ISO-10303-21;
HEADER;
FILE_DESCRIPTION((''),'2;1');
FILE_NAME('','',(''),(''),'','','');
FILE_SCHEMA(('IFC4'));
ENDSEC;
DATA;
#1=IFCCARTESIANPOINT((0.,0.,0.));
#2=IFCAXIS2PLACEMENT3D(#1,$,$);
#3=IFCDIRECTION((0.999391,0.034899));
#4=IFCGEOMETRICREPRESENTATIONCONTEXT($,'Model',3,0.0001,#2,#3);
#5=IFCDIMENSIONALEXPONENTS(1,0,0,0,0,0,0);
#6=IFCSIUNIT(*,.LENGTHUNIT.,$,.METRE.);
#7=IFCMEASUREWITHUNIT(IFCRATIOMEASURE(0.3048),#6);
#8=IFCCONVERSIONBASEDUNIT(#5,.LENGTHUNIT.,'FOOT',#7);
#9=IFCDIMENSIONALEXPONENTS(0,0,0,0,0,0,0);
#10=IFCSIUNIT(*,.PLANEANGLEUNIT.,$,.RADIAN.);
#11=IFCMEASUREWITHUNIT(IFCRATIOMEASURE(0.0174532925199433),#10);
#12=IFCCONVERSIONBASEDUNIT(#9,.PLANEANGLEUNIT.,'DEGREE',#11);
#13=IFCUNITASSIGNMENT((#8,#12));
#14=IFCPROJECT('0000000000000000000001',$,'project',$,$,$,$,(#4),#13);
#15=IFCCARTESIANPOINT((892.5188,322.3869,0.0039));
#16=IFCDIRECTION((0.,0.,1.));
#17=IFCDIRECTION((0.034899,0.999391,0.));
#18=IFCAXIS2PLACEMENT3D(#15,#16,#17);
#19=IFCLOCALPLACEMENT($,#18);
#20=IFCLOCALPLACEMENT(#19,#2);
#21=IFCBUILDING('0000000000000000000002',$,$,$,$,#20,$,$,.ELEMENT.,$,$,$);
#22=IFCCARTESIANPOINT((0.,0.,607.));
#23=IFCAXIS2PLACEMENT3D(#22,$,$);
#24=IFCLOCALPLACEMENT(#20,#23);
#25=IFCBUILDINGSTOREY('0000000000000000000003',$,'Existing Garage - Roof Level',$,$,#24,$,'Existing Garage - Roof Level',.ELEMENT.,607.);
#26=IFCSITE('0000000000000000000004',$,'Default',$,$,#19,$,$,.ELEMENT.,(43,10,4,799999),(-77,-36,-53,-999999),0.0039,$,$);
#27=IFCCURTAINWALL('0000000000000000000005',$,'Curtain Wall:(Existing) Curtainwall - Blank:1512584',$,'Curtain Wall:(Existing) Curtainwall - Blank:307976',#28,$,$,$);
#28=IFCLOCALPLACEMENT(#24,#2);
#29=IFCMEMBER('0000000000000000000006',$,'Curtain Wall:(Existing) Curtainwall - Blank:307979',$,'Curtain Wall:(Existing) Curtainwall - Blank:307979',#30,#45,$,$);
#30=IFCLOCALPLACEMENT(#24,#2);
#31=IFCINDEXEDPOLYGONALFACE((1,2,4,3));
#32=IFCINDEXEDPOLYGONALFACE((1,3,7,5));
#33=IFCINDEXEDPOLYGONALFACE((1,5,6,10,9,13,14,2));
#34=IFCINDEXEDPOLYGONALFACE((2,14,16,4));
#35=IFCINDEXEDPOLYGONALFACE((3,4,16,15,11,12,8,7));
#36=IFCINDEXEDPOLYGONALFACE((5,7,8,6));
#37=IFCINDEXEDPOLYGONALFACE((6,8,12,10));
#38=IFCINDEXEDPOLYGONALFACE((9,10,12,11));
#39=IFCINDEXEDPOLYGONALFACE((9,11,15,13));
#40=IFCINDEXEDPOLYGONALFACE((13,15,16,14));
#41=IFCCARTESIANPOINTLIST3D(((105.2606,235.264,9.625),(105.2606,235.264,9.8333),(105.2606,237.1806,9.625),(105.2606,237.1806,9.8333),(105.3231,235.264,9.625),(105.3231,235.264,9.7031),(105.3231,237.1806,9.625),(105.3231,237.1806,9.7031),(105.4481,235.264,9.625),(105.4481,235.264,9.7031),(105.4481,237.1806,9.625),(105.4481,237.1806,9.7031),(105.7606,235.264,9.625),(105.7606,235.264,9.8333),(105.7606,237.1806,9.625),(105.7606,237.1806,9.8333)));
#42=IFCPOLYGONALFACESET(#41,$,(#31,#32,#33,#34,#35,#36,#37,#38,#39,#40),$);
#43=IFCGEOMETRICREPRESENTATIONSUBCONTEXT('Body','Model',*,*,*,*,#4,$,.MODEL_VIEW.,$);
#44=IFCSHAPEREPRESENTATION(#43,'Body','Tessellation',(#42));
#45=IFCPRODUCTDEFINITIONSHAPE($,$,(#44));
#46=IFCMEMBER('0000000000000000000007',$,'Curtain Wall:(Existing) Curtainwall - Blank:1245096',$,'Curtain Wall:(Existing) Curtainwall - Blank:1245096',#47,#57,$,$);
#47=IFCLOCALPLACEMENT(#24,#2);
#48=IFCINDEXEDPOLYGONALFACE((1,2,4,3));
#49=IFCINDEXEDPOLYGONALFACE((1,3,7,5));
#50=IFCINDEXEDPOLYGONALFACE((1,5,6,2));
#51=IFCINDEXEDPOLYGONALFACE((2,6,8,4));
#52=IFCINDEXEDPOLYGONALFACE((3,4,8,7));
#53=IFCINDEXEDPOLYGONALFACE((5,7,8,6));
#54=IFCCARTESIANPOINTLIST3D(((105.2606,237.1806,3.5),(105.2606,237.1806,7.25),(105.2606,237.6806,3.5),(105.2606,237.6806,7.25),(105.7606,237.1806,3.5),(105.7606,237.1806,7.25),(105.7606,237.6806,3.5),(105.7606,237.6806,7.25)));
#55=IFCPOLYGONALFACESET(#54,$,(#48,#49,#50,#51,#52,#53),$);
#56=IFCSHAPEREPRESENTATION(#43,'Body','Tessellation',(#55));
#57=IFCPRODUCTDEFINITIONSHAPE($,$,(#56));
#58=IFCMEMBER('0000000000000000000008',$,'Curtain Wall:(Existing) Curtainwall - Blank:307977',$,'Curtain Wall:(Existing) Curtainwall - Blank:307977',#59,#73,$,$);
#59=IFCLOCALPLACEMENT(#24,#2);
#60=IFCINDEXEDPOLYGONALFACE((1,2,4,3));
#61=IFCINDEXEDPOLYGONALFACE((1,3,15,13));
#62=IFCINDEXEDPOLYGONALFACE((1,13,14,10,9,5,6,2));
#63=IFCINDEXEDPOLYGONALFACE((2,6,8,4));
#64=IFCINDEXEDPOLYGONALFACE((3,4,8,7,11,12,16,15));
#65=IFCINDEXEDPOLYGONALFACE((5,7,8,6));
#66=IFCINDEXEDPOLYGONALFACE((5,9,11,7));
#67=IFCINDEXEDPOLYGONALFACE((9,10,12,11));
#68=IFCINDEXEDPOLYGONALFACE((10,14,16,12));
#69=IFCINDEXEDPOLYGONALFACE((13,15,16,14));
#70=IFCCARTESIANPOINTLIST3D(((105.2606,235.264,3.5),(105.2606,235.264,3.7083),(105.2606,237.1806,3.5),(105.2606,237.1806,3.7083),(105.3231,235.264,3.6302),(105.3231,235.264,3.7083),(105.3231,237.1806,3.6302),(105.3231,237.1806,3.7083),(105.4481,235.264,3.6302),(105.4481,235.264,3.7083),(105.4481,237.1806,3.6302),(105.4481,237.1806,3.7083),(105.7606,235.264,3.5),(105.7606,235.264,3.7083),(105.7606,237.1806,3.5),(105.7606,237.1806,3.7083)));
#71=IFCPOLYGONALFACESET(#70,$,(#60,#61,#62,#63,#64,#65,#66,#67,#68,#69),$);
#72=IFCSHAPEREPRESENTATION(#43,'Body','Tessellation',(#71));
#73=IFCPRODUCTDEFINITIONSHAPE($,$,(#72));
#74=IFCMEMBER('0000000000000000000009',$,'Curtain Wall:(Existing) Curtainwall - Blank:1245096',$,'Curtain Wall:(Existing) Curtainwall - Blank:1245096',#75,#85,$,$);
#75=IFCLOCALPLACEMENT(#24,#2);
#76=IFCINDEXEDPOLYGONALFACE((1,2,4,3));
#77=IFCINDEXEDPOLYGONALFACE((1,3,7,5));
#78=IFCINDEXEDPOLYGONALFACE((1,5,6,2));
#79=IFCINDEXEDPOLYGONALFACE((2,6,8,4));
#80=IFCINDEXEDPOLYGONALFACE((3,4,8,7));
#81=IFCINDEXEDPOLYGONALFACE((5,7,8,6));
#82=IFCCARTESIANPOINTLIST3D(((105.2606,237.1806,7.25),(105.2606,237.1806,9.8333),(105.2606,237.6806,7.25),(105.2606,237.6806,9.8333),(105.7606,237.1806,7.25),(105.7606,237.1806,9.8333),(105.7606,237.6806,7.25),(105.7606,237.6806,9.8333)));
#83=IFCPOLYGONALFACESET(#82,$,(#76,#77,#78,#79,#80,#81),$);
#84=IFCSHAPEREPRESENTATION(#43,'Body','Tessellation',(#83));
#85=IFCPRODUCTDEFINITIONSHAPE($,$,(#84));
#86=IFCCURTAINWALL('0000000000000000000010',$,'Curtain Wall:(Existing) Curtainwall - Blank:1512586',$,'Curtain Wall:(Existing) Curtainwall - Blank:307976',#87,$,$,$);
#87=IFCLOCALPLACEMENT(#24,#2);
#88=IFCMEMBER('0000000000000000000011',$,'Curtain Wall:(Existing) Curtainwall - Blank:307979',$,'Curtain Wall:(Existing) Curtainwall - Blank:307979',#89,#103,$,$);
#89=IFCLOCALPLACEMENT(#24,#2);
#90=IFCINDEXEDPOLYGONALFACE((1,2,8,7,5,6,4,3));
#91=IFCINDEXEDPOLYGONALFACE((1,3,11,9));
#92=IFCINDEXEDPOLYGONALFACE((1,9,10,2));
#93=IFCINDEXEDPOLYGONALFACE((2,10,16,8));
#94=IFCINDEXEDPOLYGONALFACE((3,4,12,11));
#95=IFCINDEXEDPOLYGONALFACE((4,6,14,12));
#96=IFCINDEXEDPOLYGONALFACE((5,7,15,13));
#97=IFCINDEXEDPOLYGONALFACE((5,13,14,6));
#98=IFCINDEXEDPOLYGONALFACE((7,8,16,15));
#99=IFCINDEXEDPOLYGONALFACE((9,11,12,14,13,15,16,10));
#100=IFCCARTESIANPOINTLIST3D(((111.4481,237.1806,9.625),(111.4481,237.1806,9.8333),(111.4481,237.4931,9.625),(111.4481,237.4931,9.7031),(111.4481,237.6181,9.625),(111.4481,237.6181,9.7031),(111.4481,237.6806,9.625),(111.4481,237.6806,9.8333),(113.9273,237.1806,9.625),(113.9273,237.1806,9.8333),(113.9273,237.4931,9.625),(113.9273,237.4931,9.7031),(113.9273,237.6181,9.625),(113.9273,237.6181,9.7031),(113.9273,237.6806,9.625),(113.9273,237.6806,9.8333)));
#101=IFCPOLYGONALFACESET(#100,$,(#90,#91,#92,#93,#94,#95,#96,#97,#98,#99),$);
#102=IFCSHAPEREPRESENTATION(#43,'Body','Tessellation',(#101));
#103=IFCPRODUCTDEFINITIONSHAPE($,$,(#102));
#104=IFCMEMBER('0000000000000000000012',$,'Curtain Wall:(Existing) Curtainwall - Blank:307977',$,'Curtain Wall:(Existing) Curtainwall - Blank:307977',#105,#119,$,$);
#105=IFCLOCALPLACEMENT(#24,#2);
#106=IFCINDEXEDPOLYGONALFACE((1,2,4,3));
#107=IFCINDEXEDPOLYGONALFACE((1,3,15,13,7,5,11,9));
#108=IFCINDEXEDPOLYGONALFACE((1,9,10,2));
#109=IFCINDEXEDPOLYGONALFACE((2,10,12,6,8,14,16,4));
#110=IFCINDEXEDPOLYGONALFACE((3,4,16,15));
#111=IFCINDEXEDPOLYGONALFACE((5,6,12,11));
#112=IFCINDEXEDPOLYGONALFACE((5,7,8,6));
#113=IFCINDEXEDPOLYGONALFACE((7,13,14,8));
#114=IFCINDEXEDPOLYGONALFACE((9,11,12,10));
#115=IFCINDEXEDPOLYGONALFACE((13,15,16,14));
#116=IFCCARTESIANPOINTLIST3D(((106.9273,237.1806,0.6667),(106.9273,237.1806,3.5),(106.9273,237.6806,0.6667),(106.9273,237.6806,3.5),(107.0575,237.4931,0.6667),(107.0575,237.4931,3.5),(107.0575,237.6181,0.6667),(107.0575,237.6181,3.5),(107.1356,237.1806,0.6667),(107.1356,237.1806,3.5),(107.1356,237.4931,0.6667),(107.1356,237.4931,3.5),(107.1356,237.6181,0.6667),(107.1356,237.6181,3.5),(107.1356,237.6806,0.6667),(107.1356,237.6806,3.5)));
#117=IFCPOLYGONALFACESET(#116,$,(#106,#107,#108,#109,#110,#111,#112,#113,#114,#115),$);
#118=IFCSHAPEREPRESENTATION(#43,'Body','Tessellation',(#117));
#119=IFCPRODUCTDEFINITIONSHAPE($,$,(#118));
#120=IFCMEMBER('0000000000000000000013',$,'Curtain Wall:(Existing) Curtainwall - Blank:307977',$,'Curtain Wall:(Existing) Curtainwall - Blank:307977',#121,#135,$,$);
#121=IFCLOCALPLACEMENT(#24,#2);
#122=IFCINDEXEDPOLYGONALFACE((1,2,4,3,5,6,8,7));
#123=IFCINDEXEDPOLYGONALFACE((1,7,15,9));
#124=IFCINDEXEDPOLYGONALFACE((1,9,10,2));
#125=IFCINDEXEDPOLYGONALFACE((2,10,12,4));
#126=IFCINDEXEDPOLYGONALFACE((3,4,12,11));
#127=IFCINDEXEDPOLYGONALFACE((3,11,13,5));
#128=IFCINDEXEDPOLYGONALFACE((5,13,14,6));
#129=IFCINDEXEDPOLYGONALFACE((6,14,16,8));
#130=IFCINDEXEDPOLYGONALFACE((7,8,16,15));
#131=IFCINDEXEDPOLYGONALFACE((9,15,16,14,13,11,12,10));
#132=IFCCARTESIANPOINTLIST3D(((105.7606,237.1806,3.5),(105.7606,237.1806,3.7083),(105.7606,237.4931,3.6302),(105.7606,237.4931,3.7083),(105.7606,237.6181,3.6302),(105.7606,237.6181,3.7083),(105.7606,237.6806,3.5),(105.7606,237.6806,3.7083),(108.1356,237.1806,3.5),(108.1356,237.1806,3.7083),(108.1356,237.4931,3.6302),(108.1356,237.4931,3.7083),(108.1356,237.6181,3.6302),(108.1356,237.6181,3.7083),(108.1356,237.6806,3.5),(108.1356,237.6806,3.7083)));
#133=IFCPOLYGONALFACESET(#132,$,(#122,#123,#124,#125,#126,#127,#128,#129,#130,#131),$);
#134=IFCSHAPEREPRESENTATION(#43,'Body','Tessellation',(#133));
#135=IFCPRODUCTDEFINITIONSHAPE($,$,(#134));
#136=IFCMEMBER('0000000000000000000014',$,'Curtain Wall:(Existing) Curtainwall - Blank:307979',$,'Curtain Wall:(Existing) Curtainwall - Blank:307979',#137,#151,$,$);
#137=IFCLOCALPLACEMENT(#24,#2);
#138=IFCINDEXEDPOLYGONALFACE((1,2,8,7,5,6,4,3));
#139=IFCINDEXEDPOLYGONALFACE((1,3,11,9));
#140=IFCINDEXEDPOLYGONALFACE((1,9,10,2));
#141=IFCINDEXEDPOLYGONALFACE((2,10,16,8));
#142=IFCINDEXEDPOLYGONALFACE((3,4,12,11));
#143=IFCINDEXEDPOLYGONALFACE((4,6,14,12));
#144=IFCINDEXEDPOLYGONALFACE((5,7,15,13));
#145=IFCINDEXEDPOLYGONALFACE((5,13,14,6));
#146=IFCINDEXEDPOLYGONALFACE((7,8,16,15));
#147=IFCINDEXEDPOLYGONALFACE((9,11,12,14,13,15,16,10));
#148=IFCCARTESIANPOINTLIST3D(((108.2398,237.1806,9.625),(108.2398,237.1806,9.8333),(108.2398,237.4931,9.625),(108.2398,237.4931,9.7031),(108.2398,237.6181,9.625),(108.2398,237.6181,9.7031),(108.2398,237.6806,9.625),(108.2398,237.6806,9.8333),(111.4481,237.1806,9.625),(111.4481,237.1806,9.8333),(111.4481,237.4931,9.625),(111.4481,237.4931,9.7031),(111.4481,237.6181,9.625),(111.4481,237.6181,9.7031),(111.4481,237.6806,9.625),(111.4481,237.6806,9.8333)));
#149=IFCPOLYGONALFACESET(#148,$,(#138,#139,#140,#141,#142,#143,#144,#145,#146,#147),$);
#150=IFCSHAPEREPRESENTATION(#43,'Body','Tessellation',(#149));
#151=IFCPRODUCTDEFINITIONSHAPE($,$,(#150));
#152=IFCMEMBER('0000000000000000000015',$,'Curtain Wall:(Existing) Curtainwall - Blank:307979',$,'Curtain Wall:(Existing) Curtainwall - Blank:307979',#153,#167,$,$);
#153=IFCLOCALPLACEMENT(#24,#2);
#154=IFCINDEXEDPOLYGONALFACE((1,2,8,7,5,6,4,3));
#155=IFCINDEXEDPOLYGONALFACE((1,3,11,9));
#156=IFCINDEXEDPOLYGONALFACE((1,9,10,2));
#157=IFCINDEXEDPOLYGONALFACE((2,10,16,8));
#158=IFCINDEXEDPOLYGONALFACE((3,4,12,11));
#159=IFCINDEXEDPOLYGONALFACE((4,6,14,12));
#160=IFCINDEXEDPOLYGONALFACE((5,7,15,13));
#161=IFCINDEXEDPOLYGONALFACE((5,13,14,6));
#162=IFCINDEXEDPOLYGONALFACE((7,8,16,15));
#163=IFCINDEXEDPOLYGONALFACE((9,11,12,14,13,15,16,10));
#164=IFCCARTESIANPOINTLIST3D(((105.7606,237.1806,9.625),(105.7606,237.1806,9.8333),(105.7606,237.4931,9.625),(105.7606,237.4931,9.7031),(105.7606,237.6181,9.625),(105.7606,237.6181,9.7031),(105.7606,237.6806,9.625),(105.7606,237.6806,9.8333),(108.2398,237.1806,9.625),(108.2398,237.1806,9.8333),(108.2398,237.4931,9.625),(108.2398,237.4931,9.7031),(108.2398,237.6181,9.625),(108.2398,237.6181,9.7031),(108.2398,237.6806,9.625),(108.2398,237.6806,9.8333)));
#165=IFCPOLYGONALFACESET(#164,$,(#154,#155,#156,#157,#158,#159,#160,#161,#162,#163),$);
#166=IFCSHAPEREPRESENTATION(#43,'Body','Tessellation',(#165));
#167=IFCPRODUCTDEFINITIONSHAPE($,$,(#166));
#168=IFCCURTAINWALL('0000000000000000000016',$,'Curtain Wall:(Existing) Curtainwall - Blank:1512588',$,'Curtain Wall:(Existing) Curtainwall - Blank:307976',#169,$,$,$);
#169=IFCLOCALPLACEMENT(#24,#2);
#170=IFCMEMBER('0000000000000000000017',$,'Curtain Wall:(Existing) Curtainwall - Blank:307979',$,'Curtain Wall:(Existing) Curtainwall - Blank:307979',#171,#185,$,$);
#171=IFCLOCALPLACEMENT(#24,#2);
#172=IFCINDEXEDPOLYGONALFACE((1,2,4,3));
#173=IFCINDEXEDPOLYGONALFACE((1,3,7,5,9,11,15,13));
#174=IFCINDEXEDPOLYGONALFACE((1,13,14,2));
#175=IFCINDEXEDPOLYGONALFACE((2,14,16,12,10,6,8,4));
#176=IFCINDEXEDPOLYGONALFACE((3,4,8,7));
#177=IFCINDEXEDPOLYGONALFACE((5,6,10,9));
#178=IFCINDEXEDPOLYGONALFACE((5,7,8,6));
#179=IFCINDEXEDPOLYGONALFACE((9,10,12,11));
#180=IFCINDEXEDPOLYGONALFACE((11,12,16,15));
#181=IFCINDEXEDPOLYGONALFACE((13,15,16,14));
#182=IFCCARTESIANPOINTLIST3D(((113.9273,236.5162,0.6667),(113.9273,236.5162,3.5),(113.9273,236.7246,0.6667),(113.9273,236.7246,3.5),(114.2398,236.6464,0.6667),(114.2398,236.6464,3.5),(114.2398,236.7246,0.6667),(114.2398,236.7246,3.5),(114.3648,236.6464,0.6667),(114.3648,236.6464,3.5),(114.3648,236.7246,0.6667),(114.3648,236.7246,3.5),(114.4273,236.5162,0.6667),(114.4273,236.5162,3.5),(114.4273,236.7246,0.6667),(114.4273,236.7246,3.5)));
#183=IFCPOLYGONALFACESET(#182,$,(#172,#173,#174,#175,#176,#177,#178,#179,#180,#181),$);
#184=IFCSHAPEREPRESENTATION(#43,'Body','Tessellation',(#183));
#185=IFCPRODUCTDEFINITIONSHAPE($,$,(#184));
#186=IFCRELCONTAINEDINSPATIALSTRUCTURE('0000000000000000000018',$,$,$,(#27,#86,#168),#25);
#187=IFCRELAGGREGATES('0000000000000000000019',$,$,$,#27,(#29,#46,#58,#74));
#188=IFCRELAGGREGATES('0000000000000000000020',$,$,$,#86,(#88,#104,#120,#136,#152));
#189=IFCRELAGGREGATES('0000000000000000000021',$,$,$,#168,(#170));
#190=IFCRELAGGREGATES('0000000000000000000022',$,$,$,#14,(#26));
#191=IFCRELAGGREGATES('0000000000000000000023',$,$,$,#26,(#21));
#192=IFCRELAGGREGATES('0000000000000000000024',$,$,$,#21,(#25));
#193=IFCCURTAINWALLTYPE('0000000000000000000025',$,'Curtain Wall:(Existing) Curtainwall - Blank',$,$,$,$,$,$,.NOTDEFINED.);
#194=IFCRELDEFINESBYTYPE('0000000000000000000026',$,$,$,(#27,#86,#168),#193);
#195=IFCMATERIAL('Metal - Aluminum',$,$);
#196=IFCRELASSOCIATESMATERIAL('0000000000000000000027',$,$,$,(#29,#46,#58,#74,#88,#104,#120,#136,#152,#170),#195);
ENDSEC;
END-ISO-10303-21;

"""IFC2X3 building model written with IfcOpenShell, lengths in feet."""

from ifc_helpers import new_model, entity, si_unit, converted_unit, direction, frame, origin, origin_2d_with_axis, place, context, subcontext, project, spatial, polyline, rectangle, outline, extrude, material, type_object, element, aggregate, save


model = new_model("IFC2X3")

# Units and contexts
model_context = context("Model", 3, precision=0.0001, world=origin(), true_north=direction((0.999391, 0.034899)))
body_context = subcontext(model_context, "Body", "Model", "MODEL_VIEW")
ifc_project = project(units=[converted_unit("LENGTHUNIT", "FOOT", entity("IfcRatioMeasure", 0.3048), si_unit("LENGTHUNIT", "METRE"), dimensions=[1, 0, 0, 0, 0, 0, 0]), converted_unit("PLANEANGLEUNIT", "DEGREE", entity("IfcRatioMeasure", 0.0174532925199433), si_unit("PLANEANGLEUNIT", "RADIAN"), dimensions=[0, 0, 0, 0, 0, 0, 0])], contexts=[model_context])

# Site, building, storey
site_placement = place(None, frame((892.5188, 322.3869, 0.0039), z_axis=(0.0, 0.0, 1.0), x_axis=(0.034899, 0.999391, 0.0)))
site = spatial("IfcSite", under=ifc_project, at=site_placement, Name="Default", CompositionType="ELEMENT", RefLatitude=(43, 10, 4, 799999), RefLongitude=(-77, -36, -53, -999999), RefElevation=0.0039)
building_placement = place(site_placement, origin())
building = spatial("IfcBuilding", under=site, at=building_placement, CompositionType="ELEMENT")
storey_placement = place(building_placement, frame((0.0, 0.0, 607.0)))
storey = spatial("IfcBuildingStorey", under=building, at=storey_placement, Name="Existing Garage - Roof Level", LongName="Existing Garage - Roof Level", CompositionType="ELEMENT", Elevation=607.0)

# Curtain walls, members
curtain_wall_type = type_object("IfcCurtainWallType", Name="Curtain Wall:(Existing) Curtainwall - Blank", PredefinedType="NOTDEFINED")
curtain_wall_1_placement = place(storey_placement, frame((0.0, 0.0, -607.0)))
curtain_wall_1 = element("IfcCurtainWall", 1, at=curtain_wall_1_placement, inside=storey, type_object=curtain_wall_type, Name="Curtain Wall:(Existing) Curtainwall - Blank:1512584", ObjectType="Curtain Wall:(Existing) Curtainwall - Blank:307976")
ifc_material_1 = material(Name="Metal - Aluminum")
member_1_placement = place(curtain_wall_1_placement, frame((0.0, 0.0, 607.0)))
member_1 = element("IfcMember", 2, at=member_1_placement, material=ifc_material_1, Name="Curtain Wall:(Existing) Curtainwall - Blank:307979", ObjectType="Curtain Wall:(Existing) Curtainwall - Blank:307979", context=body_context, shape_type="SweptSolid", body=[
    extrude(outline(polyline([(-0.1367, -0.1875), (0.0716, -0.1875), (0.0716, -0.125), (-0.0065, -0.125), (-0.0065, 0.0), (0.0716, 0.0), (0.0716, 0.3125), (-0.1367, 0.3125), (-0.1367, -0.1875)])), frame((105.4481, 237.1806, 9.6966), z_axis=(0.0, -1.0, 0.0), x_axis=(0.0, 0.0, -1.0)), (0.0, 0.0, 1.0), 1.9167),
])
member_2_placement = place(curtain_wall_1_placement, frame((0.0, 0.0, 607.0)))
member_2 = element("IfcMember", 3, at=member_2_placement, material=ifc_material_1, Name="Curtain Wall:(Existing) Curtainwall - Blank:1245096", ObjectType="Curtain Wall:(Existing) Curtainwall - Blank:1245096", context=body_context, shape_type="SweptSolid", body=[
    extrude(rectangle(XDim=0.5, YDim=0.5, at=origin_2d_with_axis()), frame((105.5106, 237.4306, 3.5), z_axis=(0.0, 0.0, 1.0), x_axis=(-1.0, 0.0, 0.0)), (0.0, 0.0, 1.0), 3.75),
])
member_3_placement = place(curtain_wall_1_placement, frame((0.0, 0.0, 607.0)))
member_3 = element("IfcMember", 4, at=member_3_placement, material=ifc_material_1, Name="Curtain Wall:(Existing) Curtainwall - Blank:307977", ObjectType="Curtain Wall:(Existing) Curtainwall - Blank:307977", context=body_context, shape_type="SweptSolid", body=[
    extrude(outline(polyline([(-0.0716, -0.3125), (0.1367, -0.3125), (0.1367, 0.1875), (-0.0716, 0.1875), (-0.0716, 0.125), (0.0065, 0.125), (0.0065, 0.0), (-0.0716, 0.0), (-0.0716, -0.3125)])), frame((105.4481, 235.264, 3.6367), z_axis=(0.0, 1.0, 0.0), x_axis=(0.0, 0.0, -1.0)), (0.0, 0.0, 1.0), 1.9167),
])
member_4_placement = place(curtain_wall_1_placement, frame((0.0, 0.0, 607.0)))
member_4 = element("IfcMember", 5, at=member_4_placement, material=ifc_material_1, Name="Curtain Wall:(Existing) Curtainwall - Blank:1245096", ObjectType="Curtain Wall:(Existing) Curtainwall - Blank:1245096", context=body_context, shape_type="SweptSolid", body=[
    extrude(rectangle(XDim=0.5, YDim=0.5, at=origin_2d_with_axis()), frame((105.5106, 237.4306, 7.25), z_axis=(0.0, 0.0, 1.0), x_axis=(-1.0, 0.0, 0.0)), (0.0, 0.0, 1.0), 2.5833),
])
aggregate(curtain_wall_1, [member_1, member_2, member_3, member_4])
curtain_wall_2_placement = place(storey_placement, frame((0.0, 0.0, -607.0)))
curtain_wall_2 = element("IfcCurtainWall", 6, at=curtain_wall_2_placement, inside=storey, type_object=curtain_wall_type, Name="Curtain Wall:(Existing) Curtainwall - Blank:1512586", ObjectType="Curtain Wall:(Existing) Curtainwall - Blank:307976")
member_5_placement = place(curtain_wall_2_placement, frame((0.0, 0.0, 607.0)))
member_5 = element("IfcMember", 7, at=member_5_placement, material=ifc_material_1, Name="Curtain Wall:(Existing) Curtainwall - Blank:307979", ObjectType="Curtain Wall:(Existing) Curtainwall - Blank:307979", context=body_context, shape_type="SweptSolid", body=[
    extrude(outline(polyline([(-0.1367, -0.1875), (0.0716, -0.1875), (0.0716, -0.125), (-0.0065, -0.125), (-0.0065, 0.0), (0.0716, 0.0), (0.0716, 0.3125), (-0.1367, 0.3125), (-0.1367, -0.1875)])), frame((113.9273, 237.4931, 9.6966), z_axis=(-1.0, 0.0, 0.0), x_axis=(0.0, 0.0, -1.0)), (0.0, 0.0, 1.0), 2.4792),
])
member_6_placement = place(curtain_wall_2_placement, frame((0.0, 0.0, 607.0)))
member_6 = element("IfcMember", 8, at=member_6_placement, material=ifc_material_1, Name="Curtain Wall:(Existing) Curtainwall - Blank:307977", ObjectType="Curtain Wall:(Existing) Curtainwall - Blank:307977", context=body_context, shape_type="SweptSolid", body=[
    extrude(outline(polyline([(-0.0716, -0.3125), (0.1367, -0.3125), (0.1367, 0.1875), (-0.0716, 0.1875), (-0.0716, 0.125), (0.0065, 0.125), (0.0065, 0.0), (-0.0716, 0.0), (-0.0716, -0.3125)])), frame((107.064, 237.4931, 3.5), z_axis=(0.0, 0.0, -1.0), x_axis=(-1.0, 0.0, 0.0)), (0.0, 0.0, 1.0), 2.8333),
])
member_7_placement = place(curtain_wall_2_placement, frame((0.0, 0.0, 607.0)))
member_7 = element("IfcMember", 9, at=member_7_placement, material=ifc_material_1, Name="Curtain Wall:(Existing) Curtainwall - Blank:307977", ObjectType="Curtain Wall:(Existing) Curtainwall - Blank:307977", context=body_context, shape_type="SweptSolid", body=[
    extrude(outline(polyline([(-0.0716, -0.1875), (0.1367, -0.1875), (0.1367, 0.3125), (-0.0716, 0.3125), (-0.0716, 0.0), (0.0065, 0.0), (0.0065, -0.125), (-0.0716, -0.125), (-0.0716, -0.1875)])), frame((108.1356, 237.4931, 3.6367), z_axis=(-1.0, 0.0, 0.0), x_axis=(0.0, 0.0, -1.0)), (0.0, 0.0, 1.0), 2.375),
])
member_8_placement = place(curtain_wall_2_placement, frame((0.0, 0.0, 607.0)))
member_8 = element("IfcMember", 10, at=member_8_placement, material=ifc_material_1, Name="Curtain Wall:(Existing) Curtainwall - Blank:307979", ObjectType="Curtain Wall:(Existing) Curtainwall - Blank:307979", context=body_context, shape_type="SweptSolid", body=[
    extrude(outline(polyline([(-0.1367, -0.1875), (0.0716, -0.1875), (0.0716, -0.125), (-0.0065, -0.125), (-0.0065, 0.0), (0.0716, 0.0), (0.0716, 0.3125), (-0.1367, 0.3125), (-0.1367, -0.1875)])), frame((111.4481, 237.4931, 9.6966), z_axis=(-1.0, 0.0, 0.0), x_axis=(0.0, 0.0, -1.0)), (0.0, 0.0, 1.0), 3.2083),
])
member_9_placement = place(curtain_wall_2_placement, frame((0.0, 0.0, 607.0)))
member_9 = element("IfcMember", 11, at=member_9_placement, material=ifc_material_1, Name="Curtain Wall:(Existing) Curtainwall - Blank:307979", ObjectType="Curtain Wall:(Existing) Curtainwall - Blank:307979", context=body_context, shape_type="SweptSolid", body=[
    extrude(outline(polyline([(-0.1367, -0.1875), (0.0716, -0.1875), (0.0716, -0.125), (-0.0065, -0.125), (-0.0065, 0.0), (0.0716, 0.0), (0.0716, 0.3125), (-0.1367, 0.3125), (-0.1367, -0.1875)])), frame((108.2398, 237.4931, 9.6966), z_axis=(-1.0, 0.0, 0.0), x_axis=(0.0, 0.0, -1.0)), (0.0, 0.0, 1.0), 2.4792),
])
aggregate(curtain_wall_2, [member_5, member_6, member_7, member_8, member_9])
curtain_wall_3_placement = place(storey_placement, frame((0.0, 0.0, -607.0)))
curtain_wall_3 = element("IfcCurtainWall", 12, at=curtain_wall_3_placement, inside=storey, type_object=curtain_wall_type, Name="Curtain Wall:(Existing) Curtainwall - Blank:1512588", ObjectType="Curtain Wall:(Existing) Curtainwall - Blank:307976")
member_10_placement = place(curtain_wall_3_placement, frame((0.0, 0.0, 607.0)))
member_10 = element("IfcMember", 13, at=member_10_placement, material=ifc_material_1, Name="Curtain Wall:(Existing) Curtainwall - Blank:307979", ObjectType="Curtain Wall:(Existing) Curtainwall - Blank:307979", context=body_context, shape_type="SweptSolid", body=[
    extrude(outline(polyline([(0.0, -0.0716), (0.3125, -0.0716), (0.3125, 0.1367), (-0.1875, 0.1367), (-0.1875, -0.0716), (-0.125, -0.0716), (-0.125, 0.0065), (0.0, 0.0065), (0.0, -0.0716)])), frame((114.2398, 236.653, 0.6667), z_axis=(0.0, 0.0, 1.0), x_axis=(-1.0, 0.0, 0.0)), (0.0, 0.0, 1.0), 2.8333),
])
aggregate(curtain_wall_3, [member_10])

save(model, "model.ifc")
